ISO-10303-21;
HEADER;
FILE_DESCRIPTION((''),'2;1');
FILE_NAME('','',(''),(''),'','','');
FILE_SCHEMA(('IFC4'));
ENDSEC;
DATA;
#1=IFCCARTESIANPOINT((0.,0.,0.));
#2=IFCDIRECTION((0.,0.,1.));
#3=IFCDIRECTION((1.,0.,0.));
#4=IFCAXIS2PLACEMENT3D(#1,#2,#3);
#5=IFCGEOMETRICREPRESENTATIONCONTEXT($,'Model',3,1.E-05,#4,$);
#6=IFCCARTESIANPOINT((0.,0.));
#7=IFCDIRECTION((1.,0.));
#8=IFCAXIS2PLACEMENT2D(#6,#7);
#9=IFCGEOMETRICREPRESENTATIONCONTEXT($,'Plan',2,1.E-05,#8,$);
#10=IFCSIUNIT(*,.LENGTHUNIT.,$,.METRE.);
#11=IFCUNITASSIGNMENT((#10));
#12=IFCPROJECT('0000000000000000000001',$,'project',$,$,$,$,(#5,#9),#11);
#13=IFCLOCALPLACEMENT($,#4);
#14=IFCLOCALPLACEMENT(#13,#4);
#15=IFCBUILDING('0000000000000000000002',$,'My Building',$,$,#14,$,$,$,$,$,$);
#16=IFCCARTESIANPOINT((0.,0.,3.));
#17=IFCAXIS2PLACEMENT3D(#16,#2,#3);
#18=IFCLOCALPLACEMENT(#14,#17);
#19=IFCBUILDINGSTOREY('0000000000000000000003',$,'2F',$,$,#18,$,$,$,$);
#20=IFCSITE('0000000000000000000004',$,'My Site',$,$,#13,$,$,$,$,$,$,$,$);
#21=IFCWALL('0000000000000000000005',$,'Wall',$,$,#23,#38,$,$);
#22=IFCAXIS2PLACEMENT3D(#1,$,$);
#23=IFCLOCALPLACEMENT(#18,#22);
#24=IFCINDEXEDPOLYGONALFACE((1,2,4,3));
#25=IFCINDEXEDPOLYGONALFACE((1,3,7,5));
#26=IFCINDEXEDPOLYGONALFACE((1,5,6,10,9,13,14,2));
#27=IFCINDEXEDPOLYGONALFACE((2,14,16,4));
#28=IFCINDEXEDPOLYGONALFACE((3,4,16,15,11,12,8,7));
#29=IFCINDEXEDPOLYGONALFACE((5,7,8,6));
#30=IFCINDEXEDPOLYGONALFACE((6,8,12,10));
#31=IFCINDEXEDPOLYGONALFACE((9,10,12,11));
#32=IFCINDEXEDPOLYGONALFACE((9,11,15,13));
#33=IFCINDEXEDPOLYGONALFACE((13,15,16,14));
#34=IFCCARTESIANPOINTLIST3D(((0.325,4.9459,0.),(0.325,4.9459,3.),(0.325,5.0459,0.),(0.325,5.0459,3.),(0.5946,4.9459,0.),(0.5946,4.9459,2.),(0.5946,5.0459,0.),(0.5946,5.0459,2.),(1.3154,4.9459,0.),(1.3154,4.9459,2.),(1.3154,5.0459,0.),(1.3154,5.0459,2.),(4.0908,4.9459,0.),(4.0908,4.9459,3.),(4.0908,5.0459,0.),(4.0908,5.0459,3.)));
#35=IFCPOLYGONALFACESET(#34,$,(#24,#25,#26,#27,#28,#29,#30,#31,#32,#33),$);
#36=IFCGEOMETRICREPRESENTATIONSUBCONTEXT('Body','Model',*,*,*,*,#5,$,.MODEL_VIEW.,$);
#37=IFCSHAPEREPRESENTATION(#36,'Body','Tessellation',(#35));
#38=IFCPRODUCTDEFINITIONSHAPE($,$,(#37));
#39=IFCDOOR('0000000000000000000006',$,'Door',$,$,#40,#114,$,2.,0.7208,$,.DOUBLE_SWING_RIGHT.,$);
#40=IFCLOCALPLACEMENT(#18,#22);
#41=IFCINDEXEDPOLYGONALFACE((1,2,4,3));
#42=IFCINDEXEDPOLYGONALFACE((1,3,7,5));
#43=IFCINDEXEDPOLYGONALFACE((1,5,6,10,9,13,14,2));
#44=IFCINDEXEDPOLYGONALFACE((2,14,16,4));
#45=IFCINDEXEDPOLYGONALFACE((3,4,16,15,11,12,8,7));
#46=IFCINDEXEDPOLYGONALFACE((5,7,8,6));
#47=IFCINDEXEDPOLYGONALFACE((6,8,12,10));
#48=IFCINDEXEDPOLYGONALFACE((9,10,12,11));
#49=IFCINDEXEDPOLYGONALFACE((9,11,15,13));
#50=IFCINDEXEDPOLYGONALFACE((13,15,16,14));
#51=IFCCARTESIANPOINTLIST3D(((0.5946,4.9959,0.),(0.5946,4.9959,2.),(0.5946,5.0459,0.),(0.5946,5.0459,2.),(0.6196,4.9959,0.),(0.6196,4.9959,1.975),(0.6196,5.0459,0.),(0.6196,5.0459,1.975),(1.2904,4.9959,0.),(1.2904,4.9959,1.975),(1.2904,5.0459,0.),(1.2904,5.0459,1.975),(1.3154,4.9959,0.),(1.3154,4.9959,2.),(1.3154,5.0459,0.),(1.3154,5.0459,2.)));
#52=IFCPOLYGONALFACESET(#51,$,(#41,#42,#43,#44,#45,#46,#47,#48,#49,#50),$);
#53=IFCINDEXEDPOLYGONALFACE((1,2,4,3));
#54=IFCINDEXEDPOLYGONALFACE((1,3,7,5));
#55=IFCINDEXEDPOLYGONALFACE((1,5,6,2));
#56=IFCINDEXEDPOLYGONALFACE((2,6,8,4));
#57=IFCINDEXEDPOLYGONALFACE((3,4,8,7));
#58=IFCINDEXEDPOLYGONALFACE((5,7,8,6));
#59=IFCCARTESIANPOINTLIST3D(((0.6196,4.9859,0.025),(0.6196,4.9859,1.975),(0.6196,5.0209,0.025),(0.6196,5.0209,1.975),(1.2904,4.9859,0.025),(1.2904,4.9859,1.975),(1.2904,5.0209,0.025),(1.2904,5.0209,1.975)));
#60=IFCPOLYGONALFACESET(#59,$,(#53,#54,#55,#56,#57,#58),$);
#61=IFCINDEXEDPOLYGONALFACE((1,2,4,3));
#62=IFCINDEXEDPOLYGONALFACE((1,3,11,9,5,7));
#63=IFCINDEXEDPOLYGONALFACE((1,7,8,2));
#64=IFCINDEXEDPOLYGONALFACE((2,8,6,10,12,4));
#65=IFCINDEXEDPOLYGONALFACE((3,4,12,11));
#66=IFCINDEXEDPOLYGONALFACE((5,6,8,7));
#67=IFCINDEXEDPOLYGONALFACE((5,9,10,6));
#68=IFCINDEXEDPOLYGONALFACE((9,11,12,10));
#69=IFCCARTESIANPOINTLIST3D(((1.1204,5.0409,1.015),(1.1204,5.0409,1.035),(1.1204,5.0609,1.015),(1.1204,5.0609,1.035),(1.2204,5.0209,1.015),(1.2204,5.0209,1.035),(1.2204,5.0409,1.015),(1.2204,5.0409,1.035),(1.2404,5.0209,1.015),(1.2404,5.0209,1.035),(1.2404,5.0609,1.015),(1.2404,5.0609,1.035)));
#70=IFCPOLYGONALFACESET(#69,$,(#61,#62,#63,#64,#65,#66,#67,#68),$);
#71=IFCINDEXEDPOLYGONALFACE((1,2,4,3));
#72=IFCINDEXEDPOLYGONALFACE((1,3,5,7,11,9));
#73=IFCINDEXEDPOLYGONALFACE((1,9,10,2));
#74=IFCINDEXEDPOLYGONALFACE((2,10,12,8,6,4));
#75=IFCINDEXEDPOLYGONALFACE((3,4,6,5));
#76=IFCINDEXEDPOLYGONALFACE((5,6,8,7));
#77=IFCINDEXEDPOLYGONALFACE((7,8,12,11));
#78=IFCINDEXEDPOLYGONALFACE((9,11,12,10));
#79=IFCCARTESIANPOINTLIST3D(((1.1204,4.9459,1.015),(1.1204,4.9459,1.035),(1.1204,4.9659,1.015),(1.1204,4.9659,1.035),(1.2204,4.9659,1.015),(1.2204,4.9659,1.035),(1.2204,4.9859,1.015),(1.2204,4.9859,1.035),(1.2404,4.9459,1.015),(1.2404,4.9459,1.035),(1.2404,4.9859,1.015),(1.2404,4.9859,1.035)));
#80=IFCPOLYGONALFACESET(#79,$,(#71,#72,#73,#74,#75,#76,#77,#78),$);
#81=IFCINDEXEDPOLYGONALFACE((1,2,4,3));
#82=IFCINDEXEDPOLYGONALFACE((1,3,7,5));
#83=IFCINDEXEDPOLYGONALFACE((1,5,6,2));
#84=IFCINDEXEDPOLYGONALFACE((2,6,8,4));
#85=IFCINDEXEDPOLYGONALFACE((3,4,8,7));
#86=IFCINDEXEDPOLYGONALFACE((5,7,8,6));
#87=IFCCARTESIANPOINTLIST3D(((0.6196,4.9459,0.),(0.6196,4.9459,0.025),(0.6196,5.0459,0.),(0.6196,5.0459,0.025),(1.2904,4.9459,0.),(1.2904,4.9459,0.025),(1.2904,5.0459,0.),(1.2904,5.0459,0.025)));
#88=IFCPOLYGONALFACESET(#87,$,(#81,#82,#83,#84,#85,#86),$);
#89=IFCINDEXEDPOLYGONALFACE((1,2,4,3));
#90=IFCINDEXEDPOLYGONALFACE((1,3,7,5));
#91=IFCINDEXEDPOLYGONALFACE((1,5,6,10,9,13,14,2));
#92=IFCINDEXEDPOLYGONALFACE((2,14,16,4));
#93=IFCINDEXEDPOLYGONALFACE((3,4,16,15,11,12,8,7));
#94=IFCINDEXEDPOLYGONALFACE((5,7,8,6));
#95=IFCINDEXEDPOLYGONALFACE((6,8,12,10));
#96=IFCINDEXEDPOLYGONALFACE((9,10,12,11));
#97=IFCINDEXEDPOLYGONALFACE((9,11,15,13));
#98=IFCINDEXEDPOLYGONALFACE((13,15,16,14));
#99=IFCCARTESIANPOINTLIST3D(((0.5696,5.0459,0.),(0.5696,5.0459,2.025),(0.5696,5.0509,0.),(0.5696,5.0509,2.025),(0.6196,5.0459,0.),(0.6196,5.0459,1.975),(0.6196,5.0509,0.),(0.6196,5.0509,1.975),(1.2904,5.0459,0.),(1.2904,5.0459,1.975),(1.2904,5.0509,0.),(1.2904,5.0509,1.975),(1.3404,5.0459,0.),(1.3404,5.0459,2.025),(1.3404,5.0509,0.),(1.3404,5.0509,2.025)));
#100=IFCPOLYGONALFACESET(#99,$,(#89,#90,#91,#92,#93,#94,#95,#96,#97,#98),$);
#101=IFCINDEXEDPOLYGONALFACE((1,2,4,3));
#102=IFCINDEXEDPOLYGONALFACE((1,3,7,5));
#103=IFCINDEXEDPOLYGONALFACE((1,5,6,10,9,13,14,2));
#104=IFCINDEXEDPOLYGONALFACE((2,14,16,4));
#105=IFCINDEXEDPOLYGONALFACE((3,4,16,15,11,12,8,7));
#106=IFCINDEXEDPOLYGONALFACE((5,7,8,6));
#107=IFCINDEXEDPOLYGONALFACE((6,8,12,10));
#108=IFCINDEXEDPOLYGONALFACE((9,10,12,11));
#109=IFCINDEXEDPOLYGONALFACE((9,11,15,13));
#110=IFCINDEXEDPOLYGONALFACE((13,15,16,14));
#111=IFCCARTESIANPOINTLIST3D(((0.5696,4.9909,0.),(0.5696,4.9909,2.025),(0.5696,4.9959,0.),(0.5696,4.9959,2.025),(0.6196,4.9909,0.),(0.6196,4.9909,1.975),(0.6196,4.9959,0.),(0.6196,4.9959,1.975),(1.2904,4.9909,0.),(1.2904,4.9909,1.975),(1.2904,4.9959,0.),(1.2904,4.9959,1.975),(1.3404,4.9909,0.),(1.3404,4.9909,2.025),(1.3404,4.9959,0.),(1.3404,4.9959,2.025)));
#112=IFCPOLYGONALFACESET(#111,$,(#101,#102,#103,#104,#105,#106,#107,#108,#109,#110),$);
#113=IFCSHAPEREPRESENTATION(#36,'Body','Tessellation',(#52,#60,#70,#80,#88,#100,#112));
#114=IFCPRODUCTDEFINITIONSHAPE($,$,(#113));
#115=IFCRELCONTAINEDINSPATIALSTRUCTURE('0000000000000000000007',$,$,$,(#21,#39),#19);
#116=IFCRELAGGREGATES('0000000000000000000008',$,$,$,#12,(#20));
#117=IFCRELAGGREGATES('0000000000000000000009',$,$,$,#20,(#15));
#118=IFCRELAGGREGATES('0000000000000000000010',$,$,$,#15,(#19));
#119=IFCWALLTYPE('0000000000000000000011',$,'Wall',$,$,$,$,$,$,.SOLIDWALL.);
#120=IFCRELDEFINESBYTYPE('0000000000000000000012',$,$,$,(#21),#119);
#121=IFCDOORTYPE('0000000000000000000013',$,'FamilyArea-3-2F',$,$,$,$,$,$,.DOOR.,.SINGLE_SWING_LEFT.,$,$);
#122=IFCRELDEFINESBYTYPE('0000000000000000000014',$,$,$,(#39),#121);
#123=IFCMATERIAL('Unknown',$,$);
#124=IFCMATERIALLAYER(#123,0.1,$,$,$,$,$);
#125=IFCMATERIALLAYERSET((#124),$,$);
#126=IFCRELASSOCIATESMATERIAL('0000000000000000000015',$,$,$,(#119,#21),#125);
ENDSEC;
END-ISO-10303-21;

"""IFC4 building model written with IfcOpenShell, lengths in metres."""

from ifc_helpers import new_model, entity, si_unit, frame, origin_with_axes, origin_2d_with_axis, place, context, subcontext, project, spatial, line, indexed_curve, outline, extrude, shape, source, transform, mapped, material, layer, layer_set, layer_usage, type_object, type_shapes, element, fill, save


model = new_model("IFC4")

# Units and contexts
model_context = context("Model", 3, precision=1e-05, world=origin_with_axes())
plan_context = context("Plan", 2, precision=1e-05, world=origin_2d_with_axis())
body_context_1 = subcontext(model_context, "Body", "Model", "MODEL_VIEW")
body_context_2 = subcontext(plan_context, "Body", "Plan", "PLAN_VIEW")
ifc_project = project(units=[si_unit("LENGTHUNIT", "METRE")], contexts=[model_context, plan_context])

# Site, building, storey
site_placement = place(None, origin_with_axes())
site = spatial("IfcSite", under=ifc_project, at=site_placement, Name="My Site")
building_placement = place(site_placement, origin_with_axes())
building = spatial("IfcBuilding", under=site, at=building_placement, Name="My Building")
storey_placement = place(building_placement, frame((0.0, 0.0, 3.0), z_axis=(0.0, 0.0, 1.0), x_axis=(1.0, 0.0, 0.0)))
storey = spatial("IfcBuildingStorey", under=building, at=storey_placement, Name="2F")

# Shared definitions
ifc_material = material(Name="Unknown")

# Shared definitions
ifc_layer = layer(ifc_material, 0.1)
ifc_layer_set = layer_set([ifc_layer])
wall_type = type_object("IfcWallType", Name="Wall", PredefinedType="SOLIDWALL", material=ifc_layer_set)

# Wall, opening, door
ifc_layer_usage_1 = layer_usage(ifc_layer_set, "AXIS2", "POSITIVE", 0.0)
wall_1_placement = place(storey_placement, frame((4.0908, 5.0459, 0.0), z_axis=(0.0, 0.0, 1.0), x_axis=(-1.0, 0.0, 0.0)))
wall_1 = element("IfcWall", 1, at=wall_1_placement, inside=storey, type_object=wall_type, material=ifc_layer_usage_1, Name="Wall", context=body_context_1, shape_type="SweptSolid", body=[
    extrude(outline(indexed_curve([(0.0, 0.0), (0.0, 0.1), (3.7659, 0.1), (3.7659, 0.0)], segments=[line(1, 2, 3, 4, 1)])), origin_with_axes(), (0.0, 0.0, 1.0), 3.0),
])
shared_shape_1 = source(origin_with_axes(), body_context_1, "Body", "SweptSolid", [
    extrude(outline(indexed_curve([(0.0, 0.0), (0.7208, 0.0), (0.7208, 2.0), (0.0, 2.0)], segments=[line(1, 2, 3, 4, 1)])), frame((0.0, -0.6, 0.0), z_axis=(0.0, -1.0, 0.0), x_axis=(1.0, 0.0, 0.0)), (0.0, 0.0, -1.0), 1.2),
])
opening_1_placement = place(wall_1_placement, frame((2.7755, 0.0, 0.0), z_axis=(0.0, 0.0, 1.0), x_axis=(1.0, 0.0, 0.0)))
opening_1 = element("IfcOpeningElement", 2, at=opening_1_placement, cuts=wall_1, PredefinedType="OPENING", context=body_context_1, shape_type="MappedRepresentation", body=[
    mapped(shared_shape_1, transform((0.0, 0.0, 0.0), x_axis=(1.0, 0.0, 0.0), y_axis=(0.0, 1.0, 0.0), z_axis=(0.0, 0.0, 1.0), scale=1.0)),
])
door_type_1 = type_object("IfcDoorType", Name="FamilyArea-3-2F", OperationType="SINGLE_SWING_LEFT", PredefinedType="DOOR")
shared_shape_2 = source(origin_with_axes(), body_context_1, "Body", "SweptSolid", [
    extrude(outline(indexed_curve([(0.0, 0.0), (0.0, 2.0), (0.7208, 2.0), (0.7208, 0.0), (0.6958, 0.0), (0.6958, 1.975), (0.025, 1.975), (0.025, 0.0)], segments=[line(1, 2, 3, 4, 5, 6, 7, 8, 1)])), frame((0.0, 0.0, 0.0), z_axis=(0.0, -1.0, 0.0), x_axis=(1.0, 0.0, 0.0)), (0.0, 0.0, -1.0), 0.05),
    extrude(outline(indexed_curve([(0.0, 0.0), (0.6708, 0.0), (0.6708, 0.035), (0.0, 0.035)], segments=[line(1, 2, 3, 4, 1)])), frame((0.025, 0.025, 0.025), z_axis=(0.0, 0.0, 1.0), x_axis=(1.0, 0.0, 0.0)), (0.0, 0.0, 1.0), 1.95),
    extrude(outline(indexed_curve([(0.0, 0.0), (0.0, -0.04), (0.12, -0.04), (0.12, -0.02), (0.02, -0.02), (0.02, 0.0)], segments=[line(1, 2, 3, 4, 5, 6, 1)])), frame((0.075, 0.025, 1.015), z_axis=(0.0, 0.0, 1.0), x_axis=(1.0, 0.0, 0.0)), (0.0, 0.0, 1.0), 0.02),
    extrude(outline(indexed_curve([(0.0, 0.0), (0.0, 0.04), (0.12, 0.04), (0.12, 0.02), (0.02, 0.02), (0.02, 0.0)], segments=[line(1, 2, 3, 4, 5, 6, 1)])), frame((0.075, 0.06, 1.015), z_axis=(0.0, 0.0, 1.0), x_axis=(1.0, 0.0, 0.0)), (0.0, 0.0, 1.0), 0.02),
    extrude(outline(indexed_curve([(0.0, 0.0), (0.6708, 0.0), (0.6708, 0.1), (0.0, 0.1)], segments=[line(1, 2, 3, 4, 1)])), frame((0.025, 0.0, 0.0), z_axis=(0.0, 0.0, 1.0), x_axis=(1.0, 0.0, 0.0)), (0.0, 0.0, 1.0), 0.025),
    extrude(outline(indexed_curve([(0.0, 0.0), (0.0, 2.025), (0.7708, 2.025), (0.7708, 0.0), (0.7208, 0.0), (0.7208, 1.975), (0.05, 1.975), (0.05, 0.0)], segments=[line(1, 2, 3, 4, 5, 6, 7, 8, 1)])), frame((-0.025, -0.005, 0.0), z_axis=(0.0, -1.0, 0.0), x_axis=(1.0, 0.0, 0.0)), (0.0, 0.0, -1.0), 0.005),
    extrude(outline(indexed_curve([(0.0, 0.0), (0.0, 2.025), (0.7708, 2.025), (0.7708, 0.0), (0.7208, 0.0), (0.7208, 1.975), (0.05, 1.975), (0.05, 0.0)], segments=[line(1, 2, 3, 4, 5, 6, 7, 8, 1)])), frame((-0.025, 0.05, 0.0), z_axis=(0.0, -1.0, 0.0), x_axis=(1.0, 0.0, 0.0)), (0.0, 0.0, -1.0), 0.005),
])
shared_shape_3 = source(origin_with_axes(), body_context_2, "Body", "Curve2D", [
    entity("IfcIndexedPolyCurve", entity("IfcCartesianPointList2D", [[0.0, 0.0], [0.025, 0.0], [0.025, 0.05], [0.0, 0.05]]), [entity("IfcLineIndex", [1, 2, 3, 4, 1])]),
    entity("IfcIndexedPolyCurve", entity("IfcCartesianPointList2D", [[0.7208, 0.0], [0.6958, 0.0], [0.6958, 0.05], [0.7208, 0.05]]), [entity("IfcLineIndex", [1, 2, 3, 4, 1])]),
    entity("IfcIndexedPolyCurve", entity("IfcCartesianPointList2D", [[0.6958, 0.05], [0.6958, -0.6208], [0.6608, -0.6208]])),
    entity("IfcTrimmedCurve", entity("IfcEllipse", entity("IfcAxis2Placement2D", entity("IfcCartesianPoint", [0.6608, 0.05]), entity("IfcDirection", [1.0, 0.0])), 0.6358, 0.6708), [entity("IfcCartesianPoint", [0.6608, 0.7208])], [entity("IfcCartesianPoint", [0.6608, -0.6208])], True, "CARTESIAN"),
    entity("IfcIndexedPolyCurve", entity("IfcCartesianPointList2D", [[0.6958, 0.05], [0.6608, 0.05], [0.6608, 0.7208], [0.6958, 0.7208]]), [entity("IfcLineIndex", [1, 2, 3, 4, 1])]),
])
type_shapes(door_type_1, [shared_shape_2, shared_shape_3])
door_1_placement = place(opening_1_placement, frame((0.0, 0.0, 0.0), z_axis=(0.0, 0.0, 1.0), x_axis=(1.0, 0.0, 0.0)))
door_1 = element("IfcDoor", 3, at=door_1_placement, inside=storey, type_object=door_type_1, Name="Door", OperationType="DOUBLE_SWING_RIGHT", OverallHeight=2.0, OverallWidth=0.7208, shapes=[
    shape(body_context_1, "Body", "MappedRepresentation", [mapped(shared_shape_2, transform((0.0, 0.0, 0.0), x_axis=(1.0, 0.0, 0.0), y_axis=(0.0, 1.0, 0.0), z_axis=(0.0, 0.0, 1.0), scale=1.0))]),
    shape(body_context_2, "Body", "MappedRepresentation", [mapped(shared_shape_3, transform((0.0, 0.0, 0.0), x_axis=(1.0, 0.0, 0.0), y_axis=(0.0, 1.0, 0.0), z_axis=(0.0, 0.0, 1.0), scale=1.0))]),
])
fill(opening_1, door_1)

save(model, "model.ifc")
